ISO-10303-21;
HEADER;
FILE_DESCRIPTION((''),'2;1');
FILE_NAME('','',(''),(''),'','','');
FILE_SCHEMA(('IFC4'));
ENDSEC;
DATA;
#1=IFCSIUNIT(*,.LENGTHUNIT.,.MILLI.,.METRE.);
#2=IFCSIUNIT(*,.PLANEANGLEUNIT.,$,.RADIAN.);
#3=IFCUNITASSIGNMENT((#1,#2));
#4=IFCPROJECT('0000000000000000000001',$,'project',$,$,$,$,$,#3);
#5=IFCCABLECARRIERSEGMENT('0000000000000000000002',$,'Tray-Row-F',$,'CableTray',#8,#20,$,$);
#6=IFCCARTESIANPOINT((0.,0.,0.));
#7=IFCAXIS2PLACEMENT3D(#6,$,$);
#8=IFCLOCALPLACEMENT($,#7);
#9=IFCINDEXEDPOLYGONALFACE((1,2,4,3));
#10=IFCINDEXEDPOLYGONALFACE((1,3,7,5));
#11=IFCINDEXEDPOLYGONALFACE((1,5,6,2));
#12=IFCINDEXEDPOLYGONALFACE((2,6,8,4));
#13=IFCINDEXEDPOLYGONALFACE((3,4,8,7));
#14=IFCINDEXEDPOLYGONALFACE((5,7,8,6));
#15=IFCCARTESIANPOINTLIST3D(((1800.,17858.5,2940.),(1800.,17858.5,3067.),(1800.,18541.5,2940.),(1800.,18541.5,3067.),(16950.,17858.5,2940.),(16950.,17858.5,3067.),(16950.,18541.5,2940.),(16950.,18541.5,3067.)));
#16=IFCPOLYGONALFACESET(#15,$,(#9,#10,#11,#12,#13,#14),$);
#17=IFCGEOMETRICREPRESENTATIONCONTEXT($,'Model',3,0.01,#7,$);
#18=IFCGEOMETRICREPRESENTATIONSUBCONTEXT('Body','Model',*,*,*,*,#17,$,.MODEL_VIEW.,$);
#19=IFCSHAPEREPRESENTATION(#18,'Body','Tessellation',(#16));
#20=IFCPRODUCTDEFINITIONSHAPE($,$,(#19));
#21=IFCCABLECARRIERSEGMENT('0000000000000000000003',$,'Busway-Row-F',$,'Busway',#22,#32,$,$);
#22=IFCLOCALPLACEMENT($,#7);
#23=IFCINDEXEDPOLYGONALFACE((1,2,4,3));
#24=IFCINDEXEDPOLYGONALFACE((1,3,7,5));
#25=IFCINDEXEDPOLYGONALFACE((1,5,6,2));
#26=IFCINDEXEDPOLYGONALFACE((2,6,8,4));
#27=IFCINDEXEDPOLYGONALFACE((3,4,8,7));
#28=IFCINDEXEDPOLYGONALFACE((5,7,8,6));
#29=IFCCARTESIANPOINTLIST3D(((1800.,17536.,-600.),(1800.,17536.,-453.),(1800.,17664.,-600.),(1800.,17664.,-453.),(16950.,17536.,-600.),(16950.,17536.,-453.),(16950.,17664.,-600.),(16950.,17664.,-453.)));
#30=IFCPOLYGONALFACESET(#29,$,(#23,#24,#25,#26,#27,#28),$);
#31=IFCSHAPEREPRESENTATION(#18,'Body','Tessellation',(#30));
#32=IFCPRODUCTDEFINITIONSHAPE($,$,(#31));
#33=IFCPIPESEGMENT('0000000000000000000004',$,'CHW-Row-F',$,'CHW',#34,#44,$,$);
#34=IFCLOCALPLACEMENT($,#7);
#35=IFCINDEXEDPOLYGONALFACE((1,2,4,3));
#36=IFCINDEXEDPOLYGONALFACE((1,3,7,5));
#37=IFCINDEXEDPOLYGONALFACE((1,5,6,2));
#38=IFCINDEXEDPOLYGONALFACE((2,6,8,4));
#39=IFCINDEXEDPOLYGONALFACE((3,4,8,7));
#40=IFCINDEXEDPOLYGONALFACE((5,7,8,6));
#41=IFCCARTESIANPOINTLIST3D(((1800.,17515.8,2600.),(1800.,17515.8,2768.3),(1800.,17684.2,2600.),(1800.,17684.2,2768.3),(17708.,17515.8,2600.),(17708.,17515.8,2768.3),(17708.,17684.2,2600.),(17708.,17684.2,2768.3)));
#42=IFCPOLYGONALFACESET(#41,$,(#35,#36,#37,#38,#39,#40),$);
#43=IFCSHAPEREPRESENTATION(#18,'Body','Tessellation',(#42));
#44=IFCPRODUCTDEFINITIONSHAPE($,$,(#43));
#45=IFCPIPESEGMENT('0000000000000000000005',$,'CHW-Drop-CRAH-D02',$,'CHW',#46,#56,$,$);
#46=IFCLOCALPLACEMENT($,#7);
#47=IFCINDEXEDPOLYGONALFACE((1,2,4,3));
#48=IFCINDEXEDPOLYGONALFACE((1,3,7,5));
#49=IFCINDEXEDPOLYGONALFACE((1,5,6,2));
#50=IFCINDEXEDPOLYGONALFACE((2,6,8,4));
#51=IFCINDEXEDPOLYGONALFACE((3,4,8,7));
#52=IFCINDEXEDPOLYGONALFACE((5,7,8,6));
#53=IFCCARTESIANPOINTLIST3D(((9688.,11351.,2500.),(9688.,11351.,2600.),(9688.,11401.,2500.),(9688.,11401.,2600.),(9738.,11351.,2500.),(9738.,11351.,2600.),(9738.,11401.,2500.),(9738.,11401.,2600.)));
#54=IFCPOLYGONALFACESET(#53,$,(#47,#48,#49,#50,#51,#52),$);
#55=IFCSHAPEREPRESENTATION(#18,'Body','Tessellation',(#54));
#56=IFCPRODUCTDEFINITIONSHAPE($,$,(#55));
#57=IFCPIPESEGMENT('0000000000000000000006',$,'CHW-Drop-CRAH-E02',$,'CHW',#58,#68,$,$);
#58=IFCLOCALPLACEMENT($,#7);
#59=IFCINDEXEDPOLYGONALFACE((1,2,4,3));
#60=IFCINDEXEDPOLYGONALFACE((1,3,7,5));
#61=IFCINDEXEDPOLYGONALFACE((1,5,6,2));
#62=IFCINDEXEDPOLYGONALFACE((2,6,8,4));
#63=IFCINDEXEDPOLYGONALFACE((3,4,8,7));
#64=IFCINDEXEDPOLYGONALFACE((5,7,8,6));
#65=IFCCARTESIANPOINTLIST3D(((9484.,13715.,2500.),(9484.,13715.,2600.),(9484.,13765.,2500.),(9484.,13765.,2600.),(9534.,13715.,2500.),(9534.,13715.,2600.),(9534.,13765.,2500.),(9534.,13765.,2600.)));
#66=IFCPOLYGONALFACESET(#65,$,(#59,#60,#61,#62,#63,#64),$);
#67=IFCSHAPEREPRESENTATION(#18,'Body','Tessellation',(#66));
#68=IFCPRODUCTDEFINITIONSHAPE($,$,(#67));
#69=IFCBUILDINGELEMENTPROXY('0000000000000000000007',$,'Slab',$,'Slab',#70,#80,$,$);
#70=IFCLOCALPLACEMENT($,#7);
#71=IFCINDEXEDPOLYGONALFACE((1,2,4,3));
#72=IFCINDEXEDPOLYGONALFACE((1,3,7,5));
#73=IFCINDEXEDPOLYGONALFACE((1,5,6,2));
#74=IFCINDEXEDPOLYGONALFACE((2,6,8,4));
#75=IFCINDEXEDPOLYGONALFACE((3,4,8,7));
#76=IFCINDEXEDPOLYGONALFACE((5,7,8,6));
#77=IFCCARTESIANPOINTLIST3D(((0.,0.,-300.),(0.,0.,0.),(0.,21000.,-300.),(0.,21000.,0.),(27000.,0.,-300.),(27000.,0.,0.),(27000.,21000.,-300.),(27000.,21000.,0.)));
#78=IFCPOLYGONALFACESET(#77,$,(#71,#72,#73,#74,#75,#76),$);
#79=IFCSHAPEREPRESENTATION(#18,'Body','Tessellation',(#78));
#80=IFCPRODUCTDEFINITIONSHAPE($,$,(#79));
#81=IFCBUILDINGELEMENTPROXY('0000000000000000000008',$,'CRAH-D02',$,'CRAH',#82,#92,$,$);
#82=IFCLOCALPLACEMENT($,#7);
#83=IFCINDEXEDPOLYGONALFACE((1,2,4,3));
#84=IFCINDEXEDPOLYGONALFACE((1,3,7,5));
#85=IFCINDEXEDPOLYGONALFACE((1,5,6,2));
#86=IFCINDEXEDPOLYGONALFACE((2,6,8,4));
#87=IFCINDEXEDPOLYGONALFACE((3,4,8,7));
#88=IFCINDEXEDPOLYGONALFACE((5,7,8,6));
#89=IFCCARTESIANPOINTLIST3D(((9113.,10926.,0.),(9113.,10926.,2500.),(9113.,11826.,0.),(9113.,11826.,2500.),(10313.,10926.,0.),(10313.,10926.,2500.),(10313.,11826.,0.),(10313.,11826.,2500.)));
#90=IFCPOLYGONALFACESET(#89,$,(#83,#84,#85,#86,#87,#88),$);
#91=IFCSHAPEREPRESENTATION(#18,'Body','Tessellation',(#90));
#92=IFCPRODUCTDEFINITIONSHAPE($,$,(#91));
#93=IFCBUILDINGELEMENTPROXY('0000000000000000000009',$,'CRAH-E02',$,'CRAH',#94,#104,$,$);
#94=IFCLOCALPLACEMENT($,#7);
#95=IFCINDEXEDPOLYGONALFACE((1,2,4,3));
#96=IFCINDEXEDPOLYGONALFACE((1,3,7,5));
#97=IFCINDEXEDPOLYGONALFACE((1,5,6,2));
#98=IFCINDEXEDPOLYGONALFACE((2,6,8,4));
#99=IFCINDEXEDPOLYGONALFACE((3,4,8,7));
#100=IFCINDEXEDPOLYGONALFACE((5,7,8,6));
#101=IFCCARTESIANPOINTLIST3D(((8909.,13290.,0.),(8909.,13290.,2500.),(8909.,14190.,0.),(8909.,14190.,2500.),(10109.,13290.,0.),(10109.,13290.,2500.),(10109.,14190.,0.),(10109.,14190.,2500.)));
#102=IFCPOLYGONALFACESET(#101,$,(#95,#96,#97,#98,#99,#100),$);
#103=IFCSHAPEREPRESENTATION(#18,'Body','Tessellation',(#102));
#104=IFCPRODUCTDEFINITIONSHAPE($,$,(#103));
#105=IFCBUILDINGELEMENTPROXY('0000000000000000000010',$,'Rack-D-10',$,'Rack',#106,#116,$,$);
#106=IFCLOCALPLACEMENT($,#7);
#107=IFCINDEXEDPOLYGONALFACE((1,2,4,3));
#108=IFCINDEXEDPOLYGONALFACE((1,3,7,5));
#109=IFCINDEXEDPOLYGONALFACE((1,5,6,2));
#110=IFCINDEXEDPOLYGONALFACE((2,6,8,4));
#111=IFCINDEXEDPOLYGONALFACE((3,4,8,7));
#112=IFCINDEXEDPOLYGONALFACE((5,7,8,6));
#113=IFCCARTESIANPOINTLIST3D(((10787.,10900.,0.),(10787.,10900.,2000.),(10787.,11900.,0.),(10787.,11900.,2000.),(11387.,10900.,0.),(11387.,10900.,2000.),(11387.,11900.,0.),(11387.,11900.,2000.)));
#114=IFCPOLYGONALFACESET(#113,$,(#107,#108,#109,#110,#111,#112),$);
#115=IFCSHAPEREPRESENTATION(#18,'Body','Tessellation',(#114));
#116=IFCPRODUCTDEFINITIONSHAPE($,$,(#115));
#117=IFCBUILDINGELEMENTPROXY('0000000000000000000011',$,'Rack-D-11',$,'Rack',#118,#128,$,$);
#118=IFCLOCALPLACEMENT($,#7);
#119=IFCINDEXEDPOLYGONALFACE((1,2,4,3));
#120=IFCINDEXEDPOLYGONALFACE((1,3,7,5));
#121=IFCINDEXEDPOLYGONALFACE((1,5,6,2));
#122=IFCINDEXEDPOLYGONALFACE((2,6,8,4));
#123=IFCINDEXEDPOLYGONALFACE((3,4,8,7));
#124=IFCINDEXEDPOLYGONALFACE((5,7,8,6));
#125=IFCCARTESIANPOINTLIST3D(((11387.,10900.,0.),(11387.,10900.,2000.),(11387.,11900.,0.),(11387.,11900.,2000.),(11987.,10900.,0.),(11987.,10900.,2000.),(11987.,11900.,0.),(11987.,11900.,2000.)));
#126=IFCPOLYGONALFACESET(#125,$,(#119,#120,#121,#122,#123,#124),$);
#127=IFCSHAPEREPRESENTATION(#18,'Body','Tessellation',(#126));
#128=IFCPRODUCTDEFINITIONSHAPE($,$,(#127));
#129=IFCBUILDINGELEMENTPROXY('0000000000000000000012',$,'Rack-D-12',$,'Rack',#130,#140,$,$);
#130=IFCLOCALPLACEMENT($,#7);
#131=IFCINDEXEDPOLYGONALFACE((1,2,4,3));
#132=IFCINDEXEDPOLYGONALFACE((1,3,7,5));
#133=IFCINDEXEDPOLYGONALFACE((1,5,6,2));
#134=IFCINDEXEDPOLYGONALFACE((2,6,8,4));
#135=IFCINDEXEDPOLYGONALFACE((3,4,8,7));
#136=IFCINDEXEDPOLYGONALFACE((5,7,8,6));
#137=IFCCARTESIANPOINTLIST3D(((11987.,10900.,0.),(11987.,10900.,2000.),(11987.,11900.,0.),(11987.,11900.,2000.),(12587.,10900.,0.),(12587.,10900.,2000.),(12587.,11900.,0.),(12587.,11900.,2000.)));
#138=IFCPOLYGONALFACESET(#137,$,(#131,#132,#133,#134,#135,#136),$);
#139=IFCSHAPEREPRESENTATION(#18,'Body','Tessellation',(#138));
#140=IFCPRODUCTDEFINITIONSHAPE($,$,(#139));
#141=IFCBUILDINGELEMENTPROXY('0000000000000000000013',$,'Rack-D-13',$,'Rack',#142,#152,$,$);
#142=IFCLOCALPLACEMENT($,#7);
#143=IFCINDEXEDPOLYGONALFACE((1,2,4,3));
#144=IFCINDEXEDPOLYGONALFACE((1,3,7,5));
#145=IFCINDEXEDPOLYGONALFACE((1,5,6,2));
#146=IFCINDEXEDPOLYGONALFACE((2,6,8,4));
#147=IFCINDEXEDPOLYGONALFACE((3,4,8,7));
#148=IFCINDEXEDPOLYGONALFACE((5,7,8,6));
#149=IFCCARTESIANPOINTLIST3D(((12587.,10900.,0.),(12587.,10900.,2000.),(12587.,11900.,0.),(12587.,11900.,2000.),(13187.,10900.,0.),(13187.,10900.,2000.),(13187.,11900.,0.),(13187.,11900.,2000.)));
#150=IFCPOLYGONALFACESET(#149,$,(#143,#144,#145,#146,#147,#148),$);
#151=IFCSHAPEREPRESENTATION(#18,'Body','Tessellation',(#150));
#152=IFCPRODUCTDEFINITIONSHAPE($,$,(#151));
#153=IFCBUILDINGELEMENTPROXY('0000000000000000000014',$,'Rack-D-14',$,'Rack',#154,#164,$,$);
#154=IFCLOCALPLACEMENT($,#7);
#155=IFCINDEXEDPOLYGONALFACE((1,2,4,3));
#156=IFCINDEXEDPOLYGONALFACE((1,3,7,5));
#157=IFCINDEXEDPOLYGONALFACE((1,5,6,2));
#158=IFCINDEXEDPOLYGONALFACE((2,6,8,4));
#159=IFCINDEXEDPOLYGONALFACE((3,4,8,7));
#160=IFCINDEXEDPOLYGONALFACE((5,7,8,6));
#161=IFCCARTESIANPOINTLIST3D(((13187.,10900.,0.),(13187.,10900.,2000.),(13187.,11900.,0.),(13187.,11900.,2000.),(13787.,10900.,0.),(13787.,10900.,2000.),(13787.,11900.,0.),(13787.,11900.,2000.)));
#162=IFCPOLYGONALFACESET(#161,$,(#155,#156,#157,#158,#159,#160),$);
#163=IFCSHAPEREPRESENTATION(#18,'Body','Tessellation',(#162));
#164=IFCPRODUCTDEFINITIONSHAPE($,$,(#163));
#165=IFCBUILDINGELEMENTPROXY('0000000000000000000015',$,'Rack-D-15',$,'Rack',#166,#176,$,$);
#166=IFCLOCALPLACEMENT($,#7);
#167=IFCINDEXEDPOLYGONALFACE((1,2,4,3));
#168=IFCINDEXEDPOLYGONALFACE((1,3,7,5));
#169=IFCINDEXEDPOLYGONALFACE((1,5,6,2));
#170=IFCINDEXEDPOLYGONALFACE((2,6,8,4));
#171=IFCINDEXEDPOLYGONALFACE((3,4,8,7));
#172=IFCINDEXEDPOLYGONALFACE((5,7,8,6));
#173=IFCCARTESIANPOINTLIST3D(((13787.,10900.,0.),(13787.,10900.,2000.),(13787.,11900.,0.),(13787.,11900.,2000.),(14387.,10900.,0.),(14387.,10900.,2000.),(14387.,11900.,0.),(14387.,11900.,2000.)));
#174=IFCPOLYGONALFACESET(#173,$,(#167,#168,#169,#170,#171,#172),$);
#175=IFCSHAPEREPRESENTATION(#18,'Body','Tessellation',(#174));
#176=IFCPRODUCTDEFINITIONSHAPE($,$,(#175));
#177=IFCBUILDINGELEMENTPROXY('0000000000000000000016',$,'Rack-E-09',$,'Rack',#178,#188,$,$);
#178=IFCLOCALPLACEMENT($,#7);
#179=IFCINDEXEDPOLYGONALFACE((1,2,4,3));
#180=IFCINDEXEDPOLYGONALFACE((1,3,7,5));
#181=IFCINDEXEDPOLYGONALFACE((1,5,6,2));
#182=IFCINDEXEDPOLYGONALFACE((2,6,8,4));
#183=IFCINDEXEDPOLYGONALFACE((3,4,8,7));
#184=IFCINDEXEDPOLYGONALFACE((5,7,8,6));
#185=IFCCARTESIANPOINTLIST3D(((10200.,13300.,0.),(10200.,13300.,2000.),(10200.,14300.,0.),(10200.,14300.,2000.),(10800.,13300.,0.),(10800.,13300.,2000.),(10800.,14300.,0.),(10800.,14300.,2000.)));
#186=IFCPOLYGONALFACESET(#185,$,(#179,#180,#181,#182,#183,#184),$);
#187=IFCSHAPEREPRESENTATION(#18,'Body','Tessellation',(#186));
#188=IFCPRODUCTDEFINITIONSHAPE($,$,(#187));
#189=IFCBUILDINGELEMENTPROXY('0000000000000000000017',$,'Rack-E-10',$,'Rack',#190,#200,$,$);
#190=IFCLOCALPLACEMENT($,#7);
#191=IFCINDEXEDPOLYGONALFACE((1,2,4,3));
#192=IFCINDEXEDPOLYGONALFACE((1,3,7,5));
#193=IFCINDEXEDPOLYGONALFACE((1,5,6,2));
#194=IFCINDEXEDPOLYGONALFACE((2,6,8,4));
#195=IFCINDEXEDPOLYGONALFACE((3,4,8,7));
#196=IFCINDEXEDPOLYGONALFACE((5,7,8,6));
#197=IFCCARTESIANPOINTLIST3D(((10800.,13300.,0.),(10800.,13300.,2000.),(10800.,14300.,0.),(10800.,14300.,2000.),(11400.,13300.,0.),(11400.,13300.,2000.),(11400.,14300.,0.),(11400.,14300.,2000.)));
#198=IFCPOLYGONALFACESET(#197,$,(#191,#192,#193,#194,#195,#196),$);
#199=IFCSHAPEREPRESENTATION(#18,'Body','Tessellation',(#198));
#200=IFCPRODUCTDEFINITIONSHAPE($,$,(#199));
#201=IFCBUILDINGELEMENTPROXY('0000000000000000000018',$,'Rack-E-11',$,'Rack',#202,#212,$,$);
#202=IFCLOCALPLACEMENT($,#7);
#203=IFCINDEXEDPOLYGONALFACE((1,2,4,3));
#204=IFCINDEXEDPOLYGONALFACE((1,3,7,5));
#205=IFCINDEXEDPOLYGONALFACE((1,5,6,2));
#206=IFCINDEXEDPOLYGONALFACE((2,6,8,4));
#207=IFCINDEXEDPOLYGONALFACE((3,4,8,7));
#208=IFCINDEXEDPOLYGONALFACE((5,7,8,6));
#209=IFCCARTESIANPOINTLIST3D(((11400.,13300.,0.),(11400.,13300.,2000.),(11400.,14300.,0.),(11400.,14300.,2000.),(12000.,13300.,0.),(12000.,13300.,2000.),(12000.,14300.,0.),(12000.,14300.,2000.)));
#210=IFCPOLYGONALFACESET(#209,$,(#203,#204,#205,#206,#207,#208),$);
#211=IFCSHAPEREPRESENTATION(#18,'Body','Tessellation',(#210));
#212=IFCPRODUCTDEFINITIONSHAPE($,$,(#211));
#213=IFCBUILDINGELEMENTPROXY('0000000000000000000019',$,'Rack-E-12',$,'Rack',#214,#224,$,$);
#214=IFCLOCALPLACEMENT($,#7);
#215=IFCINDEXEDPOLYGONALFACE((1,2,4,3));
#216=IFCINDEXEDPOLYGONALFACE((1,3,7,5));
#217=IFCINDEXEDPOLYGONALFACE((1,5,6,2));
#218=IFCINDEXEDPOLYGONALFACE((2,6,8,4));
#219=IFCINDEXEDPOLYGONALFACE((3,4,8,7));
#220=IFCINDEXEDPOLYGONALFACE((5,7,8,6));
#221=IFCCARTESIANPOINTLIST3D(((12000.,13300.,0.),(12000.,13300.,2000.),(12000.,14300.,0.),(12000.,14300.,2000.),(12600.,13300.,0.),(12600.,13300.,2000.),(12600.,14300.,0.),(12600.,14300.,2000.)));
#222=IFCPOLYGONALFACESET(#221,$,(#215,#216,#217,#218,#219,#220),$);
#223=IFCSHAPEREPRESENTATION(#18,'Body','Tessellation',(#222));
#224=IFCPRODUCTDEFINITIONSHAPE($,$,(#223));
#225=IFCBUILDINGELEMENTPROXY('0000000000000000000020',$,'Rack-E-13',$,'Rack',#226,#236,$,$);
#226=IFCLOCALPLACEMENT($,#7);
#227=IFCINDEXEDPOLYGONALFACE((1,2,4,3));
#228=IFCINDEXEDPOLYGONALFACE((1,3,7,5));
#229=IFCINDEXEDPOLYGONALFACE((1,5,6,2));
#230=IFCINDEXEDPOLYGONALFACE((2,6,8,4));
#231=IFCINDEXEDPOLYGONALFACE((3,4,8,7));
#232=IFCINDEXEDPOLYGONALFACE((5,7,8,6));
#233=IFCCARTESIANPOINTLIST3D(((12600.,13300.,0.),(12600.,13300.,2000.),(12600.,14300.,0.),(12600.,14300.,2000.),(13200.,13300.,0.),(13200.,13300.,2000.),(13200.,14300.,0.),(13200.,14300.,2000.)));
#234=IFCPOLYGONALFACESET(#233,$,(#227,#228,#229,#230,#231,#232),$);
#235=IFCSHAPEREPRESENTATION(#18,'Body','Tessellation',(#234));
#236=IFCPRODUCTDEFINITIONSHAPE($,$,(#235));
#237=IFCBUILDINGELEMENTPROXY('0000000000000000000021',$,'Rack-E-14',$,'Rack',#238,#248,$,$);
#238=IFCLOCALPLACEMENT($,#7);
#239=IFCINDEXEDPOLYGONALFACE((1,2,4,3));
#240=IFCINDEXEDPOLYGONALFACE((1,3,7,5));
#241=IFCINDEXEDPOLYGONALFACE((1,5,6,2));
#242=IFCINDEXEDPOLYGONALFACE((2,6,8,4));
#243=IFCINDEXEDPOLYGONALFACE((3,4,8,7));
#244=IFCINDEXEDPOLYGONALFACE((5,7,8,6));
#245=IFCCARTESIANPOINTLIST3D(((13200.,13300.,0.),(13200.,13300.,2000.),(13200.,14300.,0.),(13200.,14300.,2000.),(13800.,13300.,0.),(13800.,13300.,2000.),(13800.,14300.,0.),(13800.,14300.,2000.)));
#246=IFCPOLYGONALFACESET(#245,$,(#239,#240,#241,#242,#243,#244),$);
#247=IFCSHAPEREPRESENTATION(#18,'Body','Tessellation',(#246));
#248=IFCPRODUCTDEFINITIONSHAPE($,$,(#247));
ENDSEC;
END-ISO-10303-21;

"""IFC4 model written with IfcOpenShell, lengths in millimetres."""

from ifc_helpers import new_model, si_unit, frame, origin, place, context, subcontext, project, rectangle, extrude, element, save


model = new_model("IFC4")

# Units and contexts
model_context = context("Model", 3, precision=0.01, world=origin())
body_context = subcontext(model_context, "Body", "Model", "MODEL_VIEW")
ifc_project = project(units=[si_unit("LENGTHUNIT", "METRE", prefix="MILLI"), si_unit("PLANEANGLEUNIT", "RADIAN")])

# Cable carrier segments
placement = place(None, origin())
cable_carrier_segment_1_placement = place(placement, frame((9375.0, 18200.0, 2940.0)))
element("IfcCableCarrierSegment", 1, at=cable_carrier_segment_1_placement, Name="Tray-Row-F", ObjectType="CableTray", context=body_context, shape_type="SweptSolid", body=[
    extrude(rectangle(XDim=15150.0, YDim=683.0), origin(), (0.0, 0.0, 1.0), 127.0),
])
cable_carrier_segment_2_placement = place(placement, frame((9375.0, 17600.0, -600.0)))
element("IfcCableCarrierSegment", 2, at=cable_carrier_segment_2_placement, Name="Busway-Row-F", ObjectType="Busway", context=body_context, shape_type="SweptSolid", body=[
    extrude(rectangle(XDim=15150.0, YDim=128.0), origin(), (0.0, 0.0, 1.0), 147.0),
])

# Pipe segments
pipe_segment_placement = place(placement, frame((9754.0, 17600.0, 2600.0)))
element("IfcPipeSegment", 3, at=pipe_segment_placement, Name="CHW-Row-F", ObjectType="CHW", context=body_context, shape_type="SweptSolid", body=[
    extrude(rectangle(XDim=15908.0, YDim=168.3), origin(), (0.0, 0.0, 1.0), 168.3),
])
for number, where, name in (
    (4, (9713.0, 11376.0, 2500.0), "CHW-Drop-CRAH-D02"),
    (5, (9509.0, 13740.0, 2500.0), "CHW-Drop-CRAH-E02"),
):
    element("IfcPipeSegment", number, at=place(placement, frame(where)), Name=name, ObjectType="CHW", context=body_context, shape_type="SweptSolid", body=[
        extrude(rectangle(XDim=50.0, YDim=50.0), origin(), (0.0, 0.0, 1.0), 100.0),
    ])

# Building element proxies
proxy_placement = place(placement, frame((13500.0, 10500.0, -300.0)))
element("IfcBuildingElementProxy", 6, at=proxy_placement, Name="Slab", ObjectType="Slab", context=body_context, shape_type="SweptSolid", body=[
    extrude(rectangle(XDim=27000.0, YDim=21000.0), origin(), (0.0, 0.0, 1.0), 300.0),
])
for number, where, name in (
    (7, (9713.0, 11376.0, 0.0), "CRAH-D02"),
    (8, (9509.0, 13740.0, 0.0), "CRAH-E02"),
):
    element("IfcBuildingElementProxy", number, at=place(placement, frame(where)), Name=name, ObjectType="CRAH", context=body_context, shape_type="SweptSolid", body=[
        extrude(rectangle(XDim=1200.0, YDim=900.0), origin(), (0.0, 0.0, 1.0), 2500.0),
    ])
for number, where, name in (
    (9, (11087.0, 11400.0, 0.0), "Rack-D-10"),
    (10, (11687.0, 11400.0, 0.0), "Rack-D-11"),
    (11, (12287.0, 11400.0, 0.0), "Rack-D-12"),
    (12, (12887.0, 11400.0, 0.0), "Rack-D-13"),
    (13, (13487.0, 11400.0, 0.0), "Rack-D-14"),
    (14, (14087.0, 11400.0, 0.0), "Rack-D-15"),
    (15, (10500.0, 13800.0, 0.0), "Rack-E-09"),
    (16, (11100.0, 13800.0, 0.0), "Rack-E-10"),
    (17, (11700.0, 13800.0, 0.0), "Rack-E-11"),
    (18, (12300.0, 13800.0, 0.0), "Rack-E-12"),
    (19, (12900.0, 13800.0, 0.0), "Rack-E-13"),
    (20, (13500.0, 13800.0, 0.0), "Rack-E-14"),
):
    element("IfcBuildingElementProxy", number, at=place(placement, frame(where)), Name=name, ObjectType="Rack", context=body_context, shape_type="SweptSolid", body=[
        extrude(rectangle(XDim=600.0, YDim=1000.0), origin(), (0.0, 0.0, 1.0), 2000.0),
    ])

save(model, "model.ifc")
